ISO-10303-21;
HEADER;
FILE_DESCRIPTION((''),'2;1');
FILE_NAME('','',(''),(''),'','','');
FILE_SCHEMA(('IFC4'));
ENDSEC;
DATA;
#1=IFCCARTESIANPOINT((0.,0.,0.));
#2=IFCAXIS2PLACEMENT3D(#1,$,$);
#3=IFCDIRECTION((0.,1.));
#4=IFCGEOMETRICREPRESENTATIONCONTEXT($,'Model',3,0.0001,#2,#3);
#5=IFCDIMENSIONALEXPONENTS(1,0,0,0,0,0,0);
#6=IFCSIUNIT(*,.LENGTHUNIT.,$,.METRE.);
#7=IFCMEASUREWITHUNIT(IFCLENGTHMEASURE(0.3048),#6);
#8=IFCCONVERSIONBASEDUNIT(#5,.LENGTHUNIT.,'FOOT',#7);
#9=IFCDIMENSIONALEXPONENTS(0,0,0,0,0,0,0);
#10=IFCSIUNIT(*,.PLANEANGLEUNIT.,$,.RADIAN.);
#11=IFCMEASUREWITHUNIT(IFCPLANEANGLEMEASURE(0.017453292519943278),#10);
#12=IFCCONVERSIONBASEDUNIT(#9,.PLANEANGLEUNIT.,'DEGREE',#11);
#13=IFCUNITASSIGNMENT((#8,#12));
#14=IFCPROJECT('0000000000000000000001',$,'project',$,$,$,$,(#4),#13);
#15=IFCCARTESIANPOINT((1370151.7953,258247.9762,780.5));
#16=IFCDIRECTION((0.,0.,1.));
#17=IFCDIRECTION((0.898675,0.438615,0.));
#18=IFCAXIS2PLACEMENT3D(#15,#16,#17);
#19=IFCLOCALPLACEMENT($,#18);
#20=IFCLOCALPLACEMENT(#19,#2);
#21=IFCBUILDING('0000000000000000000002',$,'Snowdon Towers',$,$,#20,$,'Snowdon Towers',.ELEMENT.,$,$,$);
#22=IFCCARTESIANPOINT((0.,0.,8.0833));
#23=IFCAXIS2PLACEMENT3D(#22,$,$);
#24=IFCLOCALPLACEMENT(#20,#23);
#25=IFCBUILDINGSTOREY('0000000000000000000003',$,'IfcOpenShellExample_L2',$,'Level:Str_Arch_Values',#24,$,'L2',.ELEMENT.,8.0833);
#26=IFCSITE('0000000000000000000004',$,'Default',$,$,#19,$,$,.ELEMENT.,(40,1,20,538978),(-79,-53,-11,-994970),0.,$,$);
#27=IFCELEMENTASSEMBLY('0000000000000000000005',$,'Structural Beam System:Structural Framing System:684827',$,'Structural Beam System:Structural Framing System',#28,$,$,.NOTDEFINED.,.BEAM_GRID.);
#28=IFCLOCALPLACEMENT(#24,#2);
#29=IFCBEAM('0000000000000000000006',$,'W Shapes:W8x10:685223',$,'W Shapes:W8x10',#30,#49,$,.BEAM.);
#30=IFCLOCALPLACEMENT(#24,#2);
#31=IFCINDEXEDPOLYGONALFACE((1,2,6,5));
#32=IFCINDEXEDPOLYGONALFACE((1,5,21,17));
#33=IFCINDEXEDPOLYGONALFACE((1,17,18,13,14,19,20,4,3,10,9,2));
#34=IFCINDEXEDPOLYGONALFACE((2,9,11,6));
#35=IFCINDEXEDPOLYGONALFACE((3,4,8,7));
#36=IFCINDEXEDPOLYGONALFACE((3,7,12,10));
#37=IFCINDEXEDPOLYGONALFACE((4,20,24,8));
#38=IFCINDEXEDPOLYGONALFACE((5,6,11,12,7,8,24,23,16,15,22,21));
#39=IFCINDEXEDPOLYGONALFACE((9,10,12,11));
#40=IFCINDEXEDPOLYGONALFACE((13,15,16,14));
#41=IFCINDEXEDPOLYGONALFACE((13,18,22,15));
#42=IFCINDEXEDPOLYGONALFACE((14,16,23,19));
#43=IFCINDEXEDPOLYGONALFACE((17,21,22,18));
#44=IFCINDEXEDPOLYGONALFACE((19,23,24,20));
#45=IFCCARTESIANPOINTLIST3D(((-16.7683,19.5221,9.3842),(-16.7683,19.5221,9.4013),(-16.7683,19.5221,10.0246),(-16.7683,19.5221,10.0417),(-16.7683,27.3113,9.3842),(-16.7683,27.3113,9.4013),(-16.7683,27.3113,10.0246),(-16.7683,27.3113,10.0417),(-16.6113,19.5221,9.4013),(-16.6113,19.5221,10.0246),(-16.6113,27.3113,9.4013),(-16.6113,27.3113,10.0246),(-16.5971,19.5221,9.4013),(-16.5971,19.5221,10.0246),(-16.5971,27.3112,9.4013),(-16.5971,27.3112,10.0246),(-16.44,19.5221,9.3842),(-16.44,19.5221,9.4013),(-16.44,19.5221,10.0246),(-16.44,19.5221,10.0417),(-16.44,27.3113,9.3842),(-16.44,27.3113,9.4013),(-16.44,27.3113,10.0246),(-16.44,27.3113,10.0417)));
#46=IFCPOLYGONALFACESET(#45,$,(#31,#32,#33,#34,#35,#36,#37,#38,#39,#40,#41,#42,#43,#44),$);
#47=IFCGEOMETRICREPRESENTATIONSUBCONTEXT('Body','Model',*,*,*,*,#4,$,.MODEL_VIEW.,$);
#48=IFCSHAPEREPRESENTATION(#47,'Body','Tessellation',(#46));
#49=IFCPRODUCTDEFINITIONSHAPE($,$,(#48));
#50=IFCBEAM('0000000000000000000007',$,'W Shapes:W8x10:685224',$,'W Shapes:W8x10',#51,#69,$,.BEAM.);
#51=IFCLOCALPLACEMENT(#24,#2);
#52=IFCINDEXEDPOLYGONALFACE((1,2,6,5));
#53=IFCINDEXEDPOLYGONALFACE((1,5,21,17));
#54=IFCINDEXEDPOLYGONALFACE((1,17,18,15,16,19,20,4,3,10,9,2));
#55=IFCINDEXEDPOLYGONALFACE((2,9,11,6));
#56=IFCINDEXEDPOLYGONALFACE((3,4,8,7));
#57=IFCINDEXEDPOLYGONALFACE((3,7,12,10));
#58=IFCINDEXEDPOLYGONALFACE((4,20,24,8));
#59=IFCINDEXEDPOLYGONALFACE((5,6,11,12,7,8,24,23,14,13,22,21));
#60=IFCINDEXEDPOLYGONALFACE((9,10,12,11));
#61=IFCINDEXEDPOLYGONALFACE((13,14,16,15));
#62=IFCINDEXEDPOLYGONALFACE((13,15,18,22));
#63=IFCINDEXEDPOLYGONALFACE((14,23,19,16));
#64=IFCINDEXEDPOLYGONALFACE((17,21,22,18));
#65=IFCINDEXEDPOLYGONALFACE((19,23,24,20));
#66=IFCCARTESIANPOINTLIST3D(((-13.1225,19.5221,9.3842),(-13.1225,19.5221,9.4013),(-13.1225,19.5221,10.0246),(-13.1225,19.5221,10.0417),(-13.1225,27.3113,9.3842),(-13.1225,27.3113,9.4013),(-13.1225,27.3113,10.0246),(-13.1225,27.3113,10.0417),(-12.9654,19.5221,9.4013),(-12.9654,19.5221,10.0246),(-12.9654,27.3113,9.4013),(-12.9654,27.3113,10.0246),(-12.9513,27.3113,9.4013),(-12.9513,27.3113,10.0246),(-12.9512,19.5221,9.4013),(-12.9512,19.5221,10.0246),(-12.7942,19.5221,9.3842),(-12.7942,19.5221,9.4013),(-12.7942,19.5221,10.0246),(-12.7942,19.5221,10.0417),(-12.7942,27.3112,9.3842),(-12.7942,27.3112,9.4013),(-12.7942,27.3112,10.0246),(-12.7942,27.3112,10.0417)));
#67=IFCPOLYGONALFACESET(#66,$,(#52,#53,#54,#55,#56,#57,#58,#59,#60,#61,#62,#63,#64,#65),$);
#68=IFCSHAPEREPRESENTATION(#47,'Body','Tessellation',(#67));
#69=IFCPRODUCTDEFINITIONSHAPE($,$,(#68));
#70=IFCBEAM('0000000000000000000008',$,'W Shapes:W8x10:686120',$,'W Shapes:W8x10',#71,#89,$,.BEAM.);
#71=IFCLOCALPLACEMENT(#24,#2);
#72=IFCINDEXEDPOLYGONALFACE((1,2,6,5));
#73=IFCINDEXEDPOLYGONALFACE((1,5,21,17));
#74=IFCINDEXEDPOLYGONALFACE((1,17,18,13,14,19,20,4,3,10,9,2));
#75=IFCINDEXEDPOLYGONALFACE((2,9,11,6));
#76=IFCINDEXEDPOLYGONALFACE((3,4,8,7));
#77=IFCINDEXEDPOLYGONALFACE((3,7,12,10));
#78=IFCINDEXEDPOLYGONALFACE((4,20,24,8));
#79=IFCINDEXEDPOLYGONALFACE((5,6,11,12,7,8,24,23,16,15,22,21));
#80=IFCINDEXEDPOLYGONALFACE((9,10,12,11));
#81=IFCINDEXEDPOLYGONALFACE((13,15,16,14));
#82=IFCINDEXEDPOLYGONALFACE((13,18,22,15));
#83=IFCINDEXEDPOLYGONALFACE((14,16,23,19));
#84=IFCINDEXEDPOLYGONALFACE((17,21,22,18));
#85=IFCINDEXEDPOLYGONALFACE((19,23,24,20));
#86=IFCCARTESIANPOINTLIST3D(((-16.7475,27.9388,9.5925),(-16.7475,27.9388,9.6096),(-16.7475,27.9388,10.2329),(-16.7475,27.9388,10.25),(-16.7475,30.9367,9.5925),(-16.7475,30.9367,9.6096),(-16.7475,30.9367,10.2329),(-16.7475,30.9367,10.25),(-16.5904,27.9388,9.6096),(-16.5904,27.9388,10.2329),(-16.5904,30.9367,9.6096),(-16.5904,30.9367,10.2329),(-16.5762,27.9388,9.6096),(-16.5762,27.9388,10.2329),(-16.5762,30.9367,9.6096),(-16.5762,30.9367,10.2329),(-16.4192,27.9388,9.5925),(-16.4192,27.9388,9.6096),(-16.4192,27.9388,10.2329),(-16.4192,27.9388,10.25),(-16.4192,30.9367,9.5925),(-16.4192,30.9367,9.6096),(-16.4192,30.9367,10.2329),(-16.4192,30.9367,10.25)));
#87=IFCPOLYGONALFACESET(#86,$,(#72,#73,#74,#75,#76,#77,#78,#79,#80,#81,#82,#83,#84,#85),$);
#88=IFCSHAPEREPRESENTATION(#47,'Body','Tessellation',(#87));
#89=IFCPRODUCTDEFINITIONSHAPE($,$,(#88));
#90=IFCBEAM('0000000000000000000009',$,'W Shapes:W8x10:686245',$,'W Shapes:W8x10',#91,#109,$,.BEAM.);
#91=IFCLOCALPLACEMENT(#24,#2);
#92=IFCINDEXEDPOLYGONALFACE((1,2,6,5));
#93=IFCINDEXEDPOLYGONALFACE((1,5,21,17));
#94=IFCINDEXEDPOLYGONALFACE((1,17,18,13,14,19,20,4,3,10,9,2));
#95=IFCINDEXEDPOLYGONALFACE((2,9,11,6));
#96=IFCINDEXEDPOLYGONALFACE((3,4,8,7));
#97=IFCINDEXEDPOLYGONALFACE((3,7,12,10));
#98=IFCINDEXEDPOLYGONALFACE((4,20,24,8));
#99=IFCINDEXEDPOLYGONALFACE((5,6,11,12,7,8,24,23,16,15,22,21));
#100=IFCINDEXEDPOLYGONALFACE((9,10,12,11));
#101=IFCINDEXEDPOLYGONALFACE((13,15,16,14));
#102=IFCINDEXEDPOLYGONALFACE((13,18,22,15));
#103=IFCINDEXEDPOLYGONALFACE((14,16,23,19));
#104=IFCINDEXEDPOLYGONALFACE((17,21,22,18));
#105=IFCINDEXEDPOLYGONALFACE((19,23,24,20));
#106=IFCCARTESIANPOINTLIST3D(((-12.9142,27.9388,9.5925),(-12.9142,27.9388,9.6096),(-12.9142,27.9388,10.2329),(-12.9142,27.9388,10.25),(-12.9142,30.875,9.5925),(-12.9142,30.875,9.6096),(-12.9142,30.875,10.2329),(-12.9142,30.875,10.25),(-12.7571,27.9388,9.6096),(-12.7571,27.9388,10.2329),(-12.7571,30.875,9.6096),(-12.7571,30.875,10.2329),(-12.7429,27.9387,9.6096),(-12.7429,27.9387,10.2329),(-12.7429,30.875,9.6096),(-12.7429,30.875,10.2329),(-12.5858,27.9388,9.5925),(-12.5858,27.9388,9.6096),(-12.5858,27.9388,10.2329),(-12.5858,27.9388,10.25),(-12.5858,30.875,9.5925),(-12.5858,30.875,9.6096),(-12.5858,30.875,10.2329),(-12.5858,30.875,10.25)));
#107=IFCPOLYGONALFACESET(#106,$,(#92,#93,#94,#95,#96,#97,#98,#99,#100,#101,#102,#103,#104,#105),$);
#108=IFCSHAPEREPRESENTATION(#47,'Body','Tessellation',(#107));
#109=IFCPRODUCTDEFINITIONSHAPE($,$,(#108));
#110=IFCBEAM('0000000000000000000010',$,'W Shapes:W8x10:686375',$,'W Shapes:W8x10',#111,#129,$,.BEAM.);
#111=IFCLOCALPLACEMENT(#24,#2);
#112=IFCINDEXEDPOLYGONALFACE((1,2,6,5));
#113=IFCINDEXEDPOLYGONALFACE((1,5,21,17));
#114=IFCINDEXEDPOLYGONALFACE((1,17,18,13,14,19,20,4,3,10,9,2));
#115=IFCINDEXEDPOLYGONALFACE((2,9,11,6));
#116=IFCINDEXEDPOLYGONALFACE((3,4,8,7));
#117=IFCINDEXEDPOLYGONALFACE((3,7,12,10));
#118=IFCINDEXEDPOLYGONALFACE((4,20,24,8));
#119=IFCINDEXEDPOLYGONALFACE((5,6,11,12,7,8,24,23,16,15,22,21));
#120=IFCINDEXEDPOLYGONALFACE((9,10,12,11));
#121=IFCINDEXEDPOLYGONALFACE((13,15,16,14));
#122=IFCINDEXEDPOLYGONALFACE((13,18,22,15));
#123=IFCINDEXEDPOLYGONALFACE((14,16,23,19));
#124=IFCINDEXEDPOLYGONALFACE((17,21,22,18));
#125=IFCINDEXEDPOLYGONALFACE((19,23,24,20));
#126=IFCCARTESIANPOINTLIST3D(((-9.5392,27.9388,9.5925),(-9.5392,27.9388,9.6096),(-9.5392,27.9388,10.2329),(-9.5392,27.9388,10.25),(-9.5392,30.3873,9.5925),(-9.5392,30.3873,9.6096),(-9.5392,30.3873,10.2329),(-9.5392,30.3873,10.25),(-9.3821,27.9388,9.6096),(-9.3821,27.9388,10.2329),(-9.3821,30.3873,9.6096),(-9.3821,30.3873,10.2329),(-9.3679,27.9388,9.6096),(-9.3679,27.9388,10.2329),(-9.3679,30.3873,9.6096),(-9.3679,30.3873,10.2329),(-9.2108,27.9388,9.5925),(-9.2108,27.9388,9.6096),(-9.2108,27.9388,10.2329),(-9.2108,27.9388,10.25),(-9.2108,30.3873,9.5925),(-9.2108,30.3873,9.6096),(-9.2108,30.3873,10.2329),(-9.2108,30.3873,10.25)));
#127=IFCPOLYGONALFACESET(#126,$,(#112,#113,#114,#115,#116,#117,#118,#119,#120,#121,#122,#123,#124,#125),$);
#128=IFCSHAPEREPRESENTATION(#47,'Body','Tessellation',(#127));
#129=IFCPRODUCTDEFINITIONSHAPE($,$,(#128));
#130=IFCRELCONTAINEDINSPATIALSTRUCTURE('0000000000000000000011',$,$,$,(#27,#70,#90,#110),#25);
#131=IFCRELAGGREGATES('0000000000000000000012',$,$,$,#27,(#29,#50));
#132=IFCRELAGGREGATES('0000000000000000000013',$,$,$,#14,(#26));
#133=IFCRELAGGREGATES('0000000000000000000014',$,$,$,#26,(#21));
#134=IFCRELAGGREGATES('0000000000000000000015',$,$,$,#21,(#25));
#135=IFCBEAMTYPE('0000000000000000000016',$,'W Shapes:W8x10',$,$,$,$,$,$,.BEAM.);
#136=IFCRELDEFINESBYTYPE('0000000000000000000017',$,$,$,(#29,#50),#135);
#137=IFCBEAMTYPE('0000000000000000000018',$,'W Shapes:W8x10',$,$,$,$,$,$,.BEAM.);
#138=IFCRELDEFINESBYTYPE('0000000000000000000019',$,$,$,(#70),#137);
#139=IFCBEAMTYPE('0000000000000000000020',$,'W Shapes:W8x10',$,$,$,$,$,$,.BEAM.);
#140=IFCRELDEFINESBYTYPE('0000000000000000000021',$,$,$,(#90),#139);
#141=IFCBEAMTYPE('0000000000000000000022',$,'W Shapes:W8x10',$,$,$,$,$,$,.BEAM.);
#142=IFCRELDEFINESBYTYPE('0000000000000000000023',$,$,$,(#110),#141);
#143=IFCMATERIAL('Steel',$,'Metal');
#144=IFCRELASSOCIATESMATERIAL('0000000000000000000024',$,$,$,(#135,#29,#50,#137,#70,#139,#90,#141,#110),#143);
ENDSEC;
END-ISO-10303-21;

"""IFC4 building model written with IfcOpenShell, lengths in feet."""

from ifc_helpers import new_model, entity, si_unit, converted_unit, direction, frame, origin, place, context, subcontext, project, spatial, indexed_curve, outline, extrude, source, transform, mapped, material, type_object, type_shapes, element, aggregate, save


model = new_model("IFC4")

# Units and contexts
model_context = context("Model", 3, precision=0.0001, world=origin(), true_north=direction((0.0, 1.0)))
body_context = subcontext(model_context, "Body", "Model", "MODEL_VIEW")
ifc_project = project(units=[converted_unit("LENGTHUNIT", "FOOT", entity("IfcLengthMeasure", 0.3048), si_unit("LENGTHUNIT", "METRE"), dimensions=[1, 0, 0, 0, 0, 0, 0]), converted_unit("PLANEANGLEUNIT", "DEGREE", entity("IfcPlaneAngleMeasure", 0.017453292519943278), si_unit("PLANEANGLEUNIT", "RADIAN"), dimensions=[0, 0, 0, 0, 0, 0, 0])], contexts=[model_context])

# Site, building, storey
site_placement = place(None, frame((1370151.7953, 258247.9762, 780.5), z_axis=(0.0, 0.0, 1.0), x_axis=(0.898675, 0.438615, 0.0)))
site = spatial("IfcSite", under=ifc_project, at=site_placement, Name="Default", CompositionType="ELEMENT", RefLatitude=(40, 1, 20, 538978), RefLongitude=(-79, -53, -11, -994970), RefElevation=0.0)
building_placement = place(site_placement, origin())
building = spatial("IfcBuilding", under=site, at=building_placement, Name="Snowdon Towers", LongName="Snowdon Towers", CompositionType="ELEMENT")
storey_placement = place(building_placement, frame((0.0, 0.0, 8.0833)))
storey = spatial("IfcBuildingStorey", under=building, at=storey_placement, Name="IfcOpenShellExample_L2", ObjectType="Level:Str_Arch_Values", LongName="L2", CompositionType="ELEMENT", Elevation=8.0833)

# Shared definitions
ifc_material = material(Name="Steel", Category="Metal")

# Element assembly, beams
assembly_1_placement = place(storey_placement, origin())
assembly_1 = element("IfcElementAssembly", 1, at=assembly_1_placement, inside=storey, Name="Structural Beam System:Structural Framing System:684827", ObjectType="Structural Beam System:Structural Framing System", AssemblyPlace="NOTDEFINED", PredefinedType="BEAM_GRID")
beam_type_1 = type_object("IfcBeamType", Name="W Shapes:W8x10", PredefinedType="BEAM", material=ifc_material)
shared_shape_1 = source(origin(), body_context, "Body", "SweptSolid", [
    extrude(outline(indexed_curve([(-0.1642, -0.3117), (-0.1642, -0.3288), (0.1642, -0.3288), (0.1642, -0.3117), (0.0071, -0.3117), (0.0071, 0.3117), (0.1642, 0.3117), (0.1642, 0.3287), (-0.1642, 0.3287), (-0.1642, 0.3117), (-0.0071, 0.3117), (-0.0071, -0.3117), (-0.1642, -0.3117)], self_intersect=False)), frame((-3.8946, 0.0, 0.0), z_axis=(-1.0, 0.0, 0.0), x_axis=(0.0, -1.0, 0.0)), (0.0, 0.0, -1.0), 7.7892),
])
type_shapes(beam_type_1, [shared_shape_1])
beam_1_placement = place(assembly_1_placement, frame((-16.6042, 23.4167, 9.7129), z_axis=(0.0, 0.0, 1.0), x_axis=(0.0, 1.0, 0.0)))
beam_1 = element("IfcBeam", 2, at=beam_1_placement, type_object=beam_type_1, material=ifc_material, Name="W Shapes:W8x10:685223", ObjectType="W Shapes:W8x10", PredefinedType="BEAM", context=body_context, shape_type="MappedRepresentation", body=[
    mapped(shared_shape_1, transform((0.0, 0.0, 0.0), scale=1.0)),
])
beam_2_placement = place(assembly_1_placement, frame((-12.9583, 23.4167, 9.7129), z_axis=(0.0, 0.0, 1.0), x_axis=(0.0, 1.0, 0.0)))
beam_2 = element("IfcBeam", 3, at=beam_2_placement, type_object=beam_type_1, material=ifc_material, Name="W Shapes:W8x10:685224", ObjectType="W Shapes:W8x10", PredefinedType="BEAM", context=body_context, shape_type="MappedRepresentation", body=[
    mapped(shared_shape_1, transform((0.0, 0.0, 0.0), scale=1.0)),
])
aggregate(assembly_1, [beam_1, beam_2])

# Beams
beam_type_2 = type_object("IfcBeamType", Name="W Shapes:W8x10", PredefinedType="BEAM", material=ifc_material)
shared_shape_2 = source(origin(), body_context, "Body", "SweptSolid", [
    extrude(outline(indexed_curve([(-0.1642, -0.3117), (-0.1642, -0.3288), (0.1642, -0.3288), (0.1642, -0.3117), (0.0071, -0.3117), (0.0071, 0.3117), (0.1642, 0.3117), (0.1642, 0.3287), (-0.1642, 0.3287), (-0.1642, 0.3117), (-0.0071, 0.3117), (-0.0071, -0.3117), (-0.1642, -0.3117)], self_intersect=False)), frame((-1.3421, 0.0, 0.0), z_axis=(-1.0, 0.0, 0.0), x_axis=(0.0, -1.0, 0.0)), (0.0, 0.0, -1.0), 2.9979),
])
type_shapes(beam_type_2, [shared_shape_2])
beam_3_placement = place(storey_placement, frame((-16.5833, 29.2808, 9.9213), z_axis=(0.0, 0.0, 1.0), x_axis=(0.0, 1.0, 0.0)))
element("IfcBeam", 4, at=beam_3_placement, inside=storey, type_object=beam_type_2, material=ifc_material, Name="W Shapes:W8x10:686120", ObjectType="W Shapes:W8x10", PredefinedType="BEAM", context=body_context, shape_type="MappedRepresentation", body=[
    mapped(shared_shape_2, transform((0.0, 0.0, 0.0), scale=1.0)),
])
beam_type_3 = type_object("IfcBeamType", Name="W Shapes:W8x10", PredefinedType="BEAM", material=ifc_material)
shared_shape_3 = source(origin(), body_context, "Body", "SweptSolid", [
    extrude(outline(indexed_curve([(-0.1642, -0.3117), (-0.1642, -0.3288), (0.1642, -0.3288), (0.1642, -0.3117), (0.0071, -0.3117), (0.0071, 0.3117), (0.1642, 0.3117), (0.1642, 0.3287), (-0.1642, 0.3287), (-0.1642, 0.3117), (-0.0071, 0.3117), (-0.0071, -0.3117), (-0.1642, -0.3117)], self_intersect=False)), frame((-1.3113, 0.0, 0.0), z_axis=(-1.0, 0.0, 0.0), x_axis=(0.0, -1.0, 0.0)), (0.0, 0.0, -1.0), 2.9363),
])
type_shapes(beam_type_3, [shared_shape_3])
beam_4_placement = place(storey_placement, frame((-12.75, 29.25, 9.9213), z_axis=(0.0, 0.0, 1.0), x_axis=(0.0, 1.0, 0.0)))
element("IfcBeam", 5, at=beam_4_placement, inside=storey, type_object=beam_type_3, material=ifc_material, Name="W Shapes:W8x10:686245", ObjectType="W Shapes:W8x10", PredefinedType="BEAM", context=body_context, shape_type="MappedRepresentation", body=[
    mapped(shared_shape_3, transform((0.0, 0.0, 0.0), scale=1.0)),
])
beam_type_4 = type_object("IfcBeamType", Name="W Shapes:W8x10", PredefinedType="BEAM", material=ifc_material)
shared_shape_4 = source(origin(), body_context, "Body", "SweptSolid", [
    extrude(outline(indexed_curve([(-0.1642, -0.3117), (-0.1642, -0.3288), (0.1642, -0.3288), (0.1642, -0.3117), (0.0071, -0.3117), (0.0071, 0.3117), (0.1642, 0.3117), (0.1642, 0.3287), (-0.1642, 0.3287), (-0.1642, 0.3117), (-0.0071, 0.3117), (-0.0071, -0.3117), (-0.1642, -0.3117)], self_intersect=False)), frame((-1.1834, 0.0, 0.0), z_axis=(-1.0, 0.0, 0.0), x_axis=(0.0, -1.0, 0.0)), (0.0, 0.0, -1.0), 2.4485),
])
type_shapes(beam_type_4, [shared_shape_4])
beam_5_placement = place(storey_placement, frame((-9.375, 29.1222, 9.9213), z_axis=(0.0, 0.0, 1.0), x_axis=(0.0, 1.0, 0.0)))
element("IfcBeam", 6, at=beam_5_placement, inside=storey, type_object=beam_type_4, material=ifc_material, Name="W Shapes:W8x10:686375", ObjectType="W Shapes:W8x10", PredefinedType="BEAM", context=body_context, shape_type="MappedRepresentation", body=[
    mapped(shared_shape_4, transform((0.0, 0.0, 0.0), scale=1.0)),
])

save(model, "model.ifc")
